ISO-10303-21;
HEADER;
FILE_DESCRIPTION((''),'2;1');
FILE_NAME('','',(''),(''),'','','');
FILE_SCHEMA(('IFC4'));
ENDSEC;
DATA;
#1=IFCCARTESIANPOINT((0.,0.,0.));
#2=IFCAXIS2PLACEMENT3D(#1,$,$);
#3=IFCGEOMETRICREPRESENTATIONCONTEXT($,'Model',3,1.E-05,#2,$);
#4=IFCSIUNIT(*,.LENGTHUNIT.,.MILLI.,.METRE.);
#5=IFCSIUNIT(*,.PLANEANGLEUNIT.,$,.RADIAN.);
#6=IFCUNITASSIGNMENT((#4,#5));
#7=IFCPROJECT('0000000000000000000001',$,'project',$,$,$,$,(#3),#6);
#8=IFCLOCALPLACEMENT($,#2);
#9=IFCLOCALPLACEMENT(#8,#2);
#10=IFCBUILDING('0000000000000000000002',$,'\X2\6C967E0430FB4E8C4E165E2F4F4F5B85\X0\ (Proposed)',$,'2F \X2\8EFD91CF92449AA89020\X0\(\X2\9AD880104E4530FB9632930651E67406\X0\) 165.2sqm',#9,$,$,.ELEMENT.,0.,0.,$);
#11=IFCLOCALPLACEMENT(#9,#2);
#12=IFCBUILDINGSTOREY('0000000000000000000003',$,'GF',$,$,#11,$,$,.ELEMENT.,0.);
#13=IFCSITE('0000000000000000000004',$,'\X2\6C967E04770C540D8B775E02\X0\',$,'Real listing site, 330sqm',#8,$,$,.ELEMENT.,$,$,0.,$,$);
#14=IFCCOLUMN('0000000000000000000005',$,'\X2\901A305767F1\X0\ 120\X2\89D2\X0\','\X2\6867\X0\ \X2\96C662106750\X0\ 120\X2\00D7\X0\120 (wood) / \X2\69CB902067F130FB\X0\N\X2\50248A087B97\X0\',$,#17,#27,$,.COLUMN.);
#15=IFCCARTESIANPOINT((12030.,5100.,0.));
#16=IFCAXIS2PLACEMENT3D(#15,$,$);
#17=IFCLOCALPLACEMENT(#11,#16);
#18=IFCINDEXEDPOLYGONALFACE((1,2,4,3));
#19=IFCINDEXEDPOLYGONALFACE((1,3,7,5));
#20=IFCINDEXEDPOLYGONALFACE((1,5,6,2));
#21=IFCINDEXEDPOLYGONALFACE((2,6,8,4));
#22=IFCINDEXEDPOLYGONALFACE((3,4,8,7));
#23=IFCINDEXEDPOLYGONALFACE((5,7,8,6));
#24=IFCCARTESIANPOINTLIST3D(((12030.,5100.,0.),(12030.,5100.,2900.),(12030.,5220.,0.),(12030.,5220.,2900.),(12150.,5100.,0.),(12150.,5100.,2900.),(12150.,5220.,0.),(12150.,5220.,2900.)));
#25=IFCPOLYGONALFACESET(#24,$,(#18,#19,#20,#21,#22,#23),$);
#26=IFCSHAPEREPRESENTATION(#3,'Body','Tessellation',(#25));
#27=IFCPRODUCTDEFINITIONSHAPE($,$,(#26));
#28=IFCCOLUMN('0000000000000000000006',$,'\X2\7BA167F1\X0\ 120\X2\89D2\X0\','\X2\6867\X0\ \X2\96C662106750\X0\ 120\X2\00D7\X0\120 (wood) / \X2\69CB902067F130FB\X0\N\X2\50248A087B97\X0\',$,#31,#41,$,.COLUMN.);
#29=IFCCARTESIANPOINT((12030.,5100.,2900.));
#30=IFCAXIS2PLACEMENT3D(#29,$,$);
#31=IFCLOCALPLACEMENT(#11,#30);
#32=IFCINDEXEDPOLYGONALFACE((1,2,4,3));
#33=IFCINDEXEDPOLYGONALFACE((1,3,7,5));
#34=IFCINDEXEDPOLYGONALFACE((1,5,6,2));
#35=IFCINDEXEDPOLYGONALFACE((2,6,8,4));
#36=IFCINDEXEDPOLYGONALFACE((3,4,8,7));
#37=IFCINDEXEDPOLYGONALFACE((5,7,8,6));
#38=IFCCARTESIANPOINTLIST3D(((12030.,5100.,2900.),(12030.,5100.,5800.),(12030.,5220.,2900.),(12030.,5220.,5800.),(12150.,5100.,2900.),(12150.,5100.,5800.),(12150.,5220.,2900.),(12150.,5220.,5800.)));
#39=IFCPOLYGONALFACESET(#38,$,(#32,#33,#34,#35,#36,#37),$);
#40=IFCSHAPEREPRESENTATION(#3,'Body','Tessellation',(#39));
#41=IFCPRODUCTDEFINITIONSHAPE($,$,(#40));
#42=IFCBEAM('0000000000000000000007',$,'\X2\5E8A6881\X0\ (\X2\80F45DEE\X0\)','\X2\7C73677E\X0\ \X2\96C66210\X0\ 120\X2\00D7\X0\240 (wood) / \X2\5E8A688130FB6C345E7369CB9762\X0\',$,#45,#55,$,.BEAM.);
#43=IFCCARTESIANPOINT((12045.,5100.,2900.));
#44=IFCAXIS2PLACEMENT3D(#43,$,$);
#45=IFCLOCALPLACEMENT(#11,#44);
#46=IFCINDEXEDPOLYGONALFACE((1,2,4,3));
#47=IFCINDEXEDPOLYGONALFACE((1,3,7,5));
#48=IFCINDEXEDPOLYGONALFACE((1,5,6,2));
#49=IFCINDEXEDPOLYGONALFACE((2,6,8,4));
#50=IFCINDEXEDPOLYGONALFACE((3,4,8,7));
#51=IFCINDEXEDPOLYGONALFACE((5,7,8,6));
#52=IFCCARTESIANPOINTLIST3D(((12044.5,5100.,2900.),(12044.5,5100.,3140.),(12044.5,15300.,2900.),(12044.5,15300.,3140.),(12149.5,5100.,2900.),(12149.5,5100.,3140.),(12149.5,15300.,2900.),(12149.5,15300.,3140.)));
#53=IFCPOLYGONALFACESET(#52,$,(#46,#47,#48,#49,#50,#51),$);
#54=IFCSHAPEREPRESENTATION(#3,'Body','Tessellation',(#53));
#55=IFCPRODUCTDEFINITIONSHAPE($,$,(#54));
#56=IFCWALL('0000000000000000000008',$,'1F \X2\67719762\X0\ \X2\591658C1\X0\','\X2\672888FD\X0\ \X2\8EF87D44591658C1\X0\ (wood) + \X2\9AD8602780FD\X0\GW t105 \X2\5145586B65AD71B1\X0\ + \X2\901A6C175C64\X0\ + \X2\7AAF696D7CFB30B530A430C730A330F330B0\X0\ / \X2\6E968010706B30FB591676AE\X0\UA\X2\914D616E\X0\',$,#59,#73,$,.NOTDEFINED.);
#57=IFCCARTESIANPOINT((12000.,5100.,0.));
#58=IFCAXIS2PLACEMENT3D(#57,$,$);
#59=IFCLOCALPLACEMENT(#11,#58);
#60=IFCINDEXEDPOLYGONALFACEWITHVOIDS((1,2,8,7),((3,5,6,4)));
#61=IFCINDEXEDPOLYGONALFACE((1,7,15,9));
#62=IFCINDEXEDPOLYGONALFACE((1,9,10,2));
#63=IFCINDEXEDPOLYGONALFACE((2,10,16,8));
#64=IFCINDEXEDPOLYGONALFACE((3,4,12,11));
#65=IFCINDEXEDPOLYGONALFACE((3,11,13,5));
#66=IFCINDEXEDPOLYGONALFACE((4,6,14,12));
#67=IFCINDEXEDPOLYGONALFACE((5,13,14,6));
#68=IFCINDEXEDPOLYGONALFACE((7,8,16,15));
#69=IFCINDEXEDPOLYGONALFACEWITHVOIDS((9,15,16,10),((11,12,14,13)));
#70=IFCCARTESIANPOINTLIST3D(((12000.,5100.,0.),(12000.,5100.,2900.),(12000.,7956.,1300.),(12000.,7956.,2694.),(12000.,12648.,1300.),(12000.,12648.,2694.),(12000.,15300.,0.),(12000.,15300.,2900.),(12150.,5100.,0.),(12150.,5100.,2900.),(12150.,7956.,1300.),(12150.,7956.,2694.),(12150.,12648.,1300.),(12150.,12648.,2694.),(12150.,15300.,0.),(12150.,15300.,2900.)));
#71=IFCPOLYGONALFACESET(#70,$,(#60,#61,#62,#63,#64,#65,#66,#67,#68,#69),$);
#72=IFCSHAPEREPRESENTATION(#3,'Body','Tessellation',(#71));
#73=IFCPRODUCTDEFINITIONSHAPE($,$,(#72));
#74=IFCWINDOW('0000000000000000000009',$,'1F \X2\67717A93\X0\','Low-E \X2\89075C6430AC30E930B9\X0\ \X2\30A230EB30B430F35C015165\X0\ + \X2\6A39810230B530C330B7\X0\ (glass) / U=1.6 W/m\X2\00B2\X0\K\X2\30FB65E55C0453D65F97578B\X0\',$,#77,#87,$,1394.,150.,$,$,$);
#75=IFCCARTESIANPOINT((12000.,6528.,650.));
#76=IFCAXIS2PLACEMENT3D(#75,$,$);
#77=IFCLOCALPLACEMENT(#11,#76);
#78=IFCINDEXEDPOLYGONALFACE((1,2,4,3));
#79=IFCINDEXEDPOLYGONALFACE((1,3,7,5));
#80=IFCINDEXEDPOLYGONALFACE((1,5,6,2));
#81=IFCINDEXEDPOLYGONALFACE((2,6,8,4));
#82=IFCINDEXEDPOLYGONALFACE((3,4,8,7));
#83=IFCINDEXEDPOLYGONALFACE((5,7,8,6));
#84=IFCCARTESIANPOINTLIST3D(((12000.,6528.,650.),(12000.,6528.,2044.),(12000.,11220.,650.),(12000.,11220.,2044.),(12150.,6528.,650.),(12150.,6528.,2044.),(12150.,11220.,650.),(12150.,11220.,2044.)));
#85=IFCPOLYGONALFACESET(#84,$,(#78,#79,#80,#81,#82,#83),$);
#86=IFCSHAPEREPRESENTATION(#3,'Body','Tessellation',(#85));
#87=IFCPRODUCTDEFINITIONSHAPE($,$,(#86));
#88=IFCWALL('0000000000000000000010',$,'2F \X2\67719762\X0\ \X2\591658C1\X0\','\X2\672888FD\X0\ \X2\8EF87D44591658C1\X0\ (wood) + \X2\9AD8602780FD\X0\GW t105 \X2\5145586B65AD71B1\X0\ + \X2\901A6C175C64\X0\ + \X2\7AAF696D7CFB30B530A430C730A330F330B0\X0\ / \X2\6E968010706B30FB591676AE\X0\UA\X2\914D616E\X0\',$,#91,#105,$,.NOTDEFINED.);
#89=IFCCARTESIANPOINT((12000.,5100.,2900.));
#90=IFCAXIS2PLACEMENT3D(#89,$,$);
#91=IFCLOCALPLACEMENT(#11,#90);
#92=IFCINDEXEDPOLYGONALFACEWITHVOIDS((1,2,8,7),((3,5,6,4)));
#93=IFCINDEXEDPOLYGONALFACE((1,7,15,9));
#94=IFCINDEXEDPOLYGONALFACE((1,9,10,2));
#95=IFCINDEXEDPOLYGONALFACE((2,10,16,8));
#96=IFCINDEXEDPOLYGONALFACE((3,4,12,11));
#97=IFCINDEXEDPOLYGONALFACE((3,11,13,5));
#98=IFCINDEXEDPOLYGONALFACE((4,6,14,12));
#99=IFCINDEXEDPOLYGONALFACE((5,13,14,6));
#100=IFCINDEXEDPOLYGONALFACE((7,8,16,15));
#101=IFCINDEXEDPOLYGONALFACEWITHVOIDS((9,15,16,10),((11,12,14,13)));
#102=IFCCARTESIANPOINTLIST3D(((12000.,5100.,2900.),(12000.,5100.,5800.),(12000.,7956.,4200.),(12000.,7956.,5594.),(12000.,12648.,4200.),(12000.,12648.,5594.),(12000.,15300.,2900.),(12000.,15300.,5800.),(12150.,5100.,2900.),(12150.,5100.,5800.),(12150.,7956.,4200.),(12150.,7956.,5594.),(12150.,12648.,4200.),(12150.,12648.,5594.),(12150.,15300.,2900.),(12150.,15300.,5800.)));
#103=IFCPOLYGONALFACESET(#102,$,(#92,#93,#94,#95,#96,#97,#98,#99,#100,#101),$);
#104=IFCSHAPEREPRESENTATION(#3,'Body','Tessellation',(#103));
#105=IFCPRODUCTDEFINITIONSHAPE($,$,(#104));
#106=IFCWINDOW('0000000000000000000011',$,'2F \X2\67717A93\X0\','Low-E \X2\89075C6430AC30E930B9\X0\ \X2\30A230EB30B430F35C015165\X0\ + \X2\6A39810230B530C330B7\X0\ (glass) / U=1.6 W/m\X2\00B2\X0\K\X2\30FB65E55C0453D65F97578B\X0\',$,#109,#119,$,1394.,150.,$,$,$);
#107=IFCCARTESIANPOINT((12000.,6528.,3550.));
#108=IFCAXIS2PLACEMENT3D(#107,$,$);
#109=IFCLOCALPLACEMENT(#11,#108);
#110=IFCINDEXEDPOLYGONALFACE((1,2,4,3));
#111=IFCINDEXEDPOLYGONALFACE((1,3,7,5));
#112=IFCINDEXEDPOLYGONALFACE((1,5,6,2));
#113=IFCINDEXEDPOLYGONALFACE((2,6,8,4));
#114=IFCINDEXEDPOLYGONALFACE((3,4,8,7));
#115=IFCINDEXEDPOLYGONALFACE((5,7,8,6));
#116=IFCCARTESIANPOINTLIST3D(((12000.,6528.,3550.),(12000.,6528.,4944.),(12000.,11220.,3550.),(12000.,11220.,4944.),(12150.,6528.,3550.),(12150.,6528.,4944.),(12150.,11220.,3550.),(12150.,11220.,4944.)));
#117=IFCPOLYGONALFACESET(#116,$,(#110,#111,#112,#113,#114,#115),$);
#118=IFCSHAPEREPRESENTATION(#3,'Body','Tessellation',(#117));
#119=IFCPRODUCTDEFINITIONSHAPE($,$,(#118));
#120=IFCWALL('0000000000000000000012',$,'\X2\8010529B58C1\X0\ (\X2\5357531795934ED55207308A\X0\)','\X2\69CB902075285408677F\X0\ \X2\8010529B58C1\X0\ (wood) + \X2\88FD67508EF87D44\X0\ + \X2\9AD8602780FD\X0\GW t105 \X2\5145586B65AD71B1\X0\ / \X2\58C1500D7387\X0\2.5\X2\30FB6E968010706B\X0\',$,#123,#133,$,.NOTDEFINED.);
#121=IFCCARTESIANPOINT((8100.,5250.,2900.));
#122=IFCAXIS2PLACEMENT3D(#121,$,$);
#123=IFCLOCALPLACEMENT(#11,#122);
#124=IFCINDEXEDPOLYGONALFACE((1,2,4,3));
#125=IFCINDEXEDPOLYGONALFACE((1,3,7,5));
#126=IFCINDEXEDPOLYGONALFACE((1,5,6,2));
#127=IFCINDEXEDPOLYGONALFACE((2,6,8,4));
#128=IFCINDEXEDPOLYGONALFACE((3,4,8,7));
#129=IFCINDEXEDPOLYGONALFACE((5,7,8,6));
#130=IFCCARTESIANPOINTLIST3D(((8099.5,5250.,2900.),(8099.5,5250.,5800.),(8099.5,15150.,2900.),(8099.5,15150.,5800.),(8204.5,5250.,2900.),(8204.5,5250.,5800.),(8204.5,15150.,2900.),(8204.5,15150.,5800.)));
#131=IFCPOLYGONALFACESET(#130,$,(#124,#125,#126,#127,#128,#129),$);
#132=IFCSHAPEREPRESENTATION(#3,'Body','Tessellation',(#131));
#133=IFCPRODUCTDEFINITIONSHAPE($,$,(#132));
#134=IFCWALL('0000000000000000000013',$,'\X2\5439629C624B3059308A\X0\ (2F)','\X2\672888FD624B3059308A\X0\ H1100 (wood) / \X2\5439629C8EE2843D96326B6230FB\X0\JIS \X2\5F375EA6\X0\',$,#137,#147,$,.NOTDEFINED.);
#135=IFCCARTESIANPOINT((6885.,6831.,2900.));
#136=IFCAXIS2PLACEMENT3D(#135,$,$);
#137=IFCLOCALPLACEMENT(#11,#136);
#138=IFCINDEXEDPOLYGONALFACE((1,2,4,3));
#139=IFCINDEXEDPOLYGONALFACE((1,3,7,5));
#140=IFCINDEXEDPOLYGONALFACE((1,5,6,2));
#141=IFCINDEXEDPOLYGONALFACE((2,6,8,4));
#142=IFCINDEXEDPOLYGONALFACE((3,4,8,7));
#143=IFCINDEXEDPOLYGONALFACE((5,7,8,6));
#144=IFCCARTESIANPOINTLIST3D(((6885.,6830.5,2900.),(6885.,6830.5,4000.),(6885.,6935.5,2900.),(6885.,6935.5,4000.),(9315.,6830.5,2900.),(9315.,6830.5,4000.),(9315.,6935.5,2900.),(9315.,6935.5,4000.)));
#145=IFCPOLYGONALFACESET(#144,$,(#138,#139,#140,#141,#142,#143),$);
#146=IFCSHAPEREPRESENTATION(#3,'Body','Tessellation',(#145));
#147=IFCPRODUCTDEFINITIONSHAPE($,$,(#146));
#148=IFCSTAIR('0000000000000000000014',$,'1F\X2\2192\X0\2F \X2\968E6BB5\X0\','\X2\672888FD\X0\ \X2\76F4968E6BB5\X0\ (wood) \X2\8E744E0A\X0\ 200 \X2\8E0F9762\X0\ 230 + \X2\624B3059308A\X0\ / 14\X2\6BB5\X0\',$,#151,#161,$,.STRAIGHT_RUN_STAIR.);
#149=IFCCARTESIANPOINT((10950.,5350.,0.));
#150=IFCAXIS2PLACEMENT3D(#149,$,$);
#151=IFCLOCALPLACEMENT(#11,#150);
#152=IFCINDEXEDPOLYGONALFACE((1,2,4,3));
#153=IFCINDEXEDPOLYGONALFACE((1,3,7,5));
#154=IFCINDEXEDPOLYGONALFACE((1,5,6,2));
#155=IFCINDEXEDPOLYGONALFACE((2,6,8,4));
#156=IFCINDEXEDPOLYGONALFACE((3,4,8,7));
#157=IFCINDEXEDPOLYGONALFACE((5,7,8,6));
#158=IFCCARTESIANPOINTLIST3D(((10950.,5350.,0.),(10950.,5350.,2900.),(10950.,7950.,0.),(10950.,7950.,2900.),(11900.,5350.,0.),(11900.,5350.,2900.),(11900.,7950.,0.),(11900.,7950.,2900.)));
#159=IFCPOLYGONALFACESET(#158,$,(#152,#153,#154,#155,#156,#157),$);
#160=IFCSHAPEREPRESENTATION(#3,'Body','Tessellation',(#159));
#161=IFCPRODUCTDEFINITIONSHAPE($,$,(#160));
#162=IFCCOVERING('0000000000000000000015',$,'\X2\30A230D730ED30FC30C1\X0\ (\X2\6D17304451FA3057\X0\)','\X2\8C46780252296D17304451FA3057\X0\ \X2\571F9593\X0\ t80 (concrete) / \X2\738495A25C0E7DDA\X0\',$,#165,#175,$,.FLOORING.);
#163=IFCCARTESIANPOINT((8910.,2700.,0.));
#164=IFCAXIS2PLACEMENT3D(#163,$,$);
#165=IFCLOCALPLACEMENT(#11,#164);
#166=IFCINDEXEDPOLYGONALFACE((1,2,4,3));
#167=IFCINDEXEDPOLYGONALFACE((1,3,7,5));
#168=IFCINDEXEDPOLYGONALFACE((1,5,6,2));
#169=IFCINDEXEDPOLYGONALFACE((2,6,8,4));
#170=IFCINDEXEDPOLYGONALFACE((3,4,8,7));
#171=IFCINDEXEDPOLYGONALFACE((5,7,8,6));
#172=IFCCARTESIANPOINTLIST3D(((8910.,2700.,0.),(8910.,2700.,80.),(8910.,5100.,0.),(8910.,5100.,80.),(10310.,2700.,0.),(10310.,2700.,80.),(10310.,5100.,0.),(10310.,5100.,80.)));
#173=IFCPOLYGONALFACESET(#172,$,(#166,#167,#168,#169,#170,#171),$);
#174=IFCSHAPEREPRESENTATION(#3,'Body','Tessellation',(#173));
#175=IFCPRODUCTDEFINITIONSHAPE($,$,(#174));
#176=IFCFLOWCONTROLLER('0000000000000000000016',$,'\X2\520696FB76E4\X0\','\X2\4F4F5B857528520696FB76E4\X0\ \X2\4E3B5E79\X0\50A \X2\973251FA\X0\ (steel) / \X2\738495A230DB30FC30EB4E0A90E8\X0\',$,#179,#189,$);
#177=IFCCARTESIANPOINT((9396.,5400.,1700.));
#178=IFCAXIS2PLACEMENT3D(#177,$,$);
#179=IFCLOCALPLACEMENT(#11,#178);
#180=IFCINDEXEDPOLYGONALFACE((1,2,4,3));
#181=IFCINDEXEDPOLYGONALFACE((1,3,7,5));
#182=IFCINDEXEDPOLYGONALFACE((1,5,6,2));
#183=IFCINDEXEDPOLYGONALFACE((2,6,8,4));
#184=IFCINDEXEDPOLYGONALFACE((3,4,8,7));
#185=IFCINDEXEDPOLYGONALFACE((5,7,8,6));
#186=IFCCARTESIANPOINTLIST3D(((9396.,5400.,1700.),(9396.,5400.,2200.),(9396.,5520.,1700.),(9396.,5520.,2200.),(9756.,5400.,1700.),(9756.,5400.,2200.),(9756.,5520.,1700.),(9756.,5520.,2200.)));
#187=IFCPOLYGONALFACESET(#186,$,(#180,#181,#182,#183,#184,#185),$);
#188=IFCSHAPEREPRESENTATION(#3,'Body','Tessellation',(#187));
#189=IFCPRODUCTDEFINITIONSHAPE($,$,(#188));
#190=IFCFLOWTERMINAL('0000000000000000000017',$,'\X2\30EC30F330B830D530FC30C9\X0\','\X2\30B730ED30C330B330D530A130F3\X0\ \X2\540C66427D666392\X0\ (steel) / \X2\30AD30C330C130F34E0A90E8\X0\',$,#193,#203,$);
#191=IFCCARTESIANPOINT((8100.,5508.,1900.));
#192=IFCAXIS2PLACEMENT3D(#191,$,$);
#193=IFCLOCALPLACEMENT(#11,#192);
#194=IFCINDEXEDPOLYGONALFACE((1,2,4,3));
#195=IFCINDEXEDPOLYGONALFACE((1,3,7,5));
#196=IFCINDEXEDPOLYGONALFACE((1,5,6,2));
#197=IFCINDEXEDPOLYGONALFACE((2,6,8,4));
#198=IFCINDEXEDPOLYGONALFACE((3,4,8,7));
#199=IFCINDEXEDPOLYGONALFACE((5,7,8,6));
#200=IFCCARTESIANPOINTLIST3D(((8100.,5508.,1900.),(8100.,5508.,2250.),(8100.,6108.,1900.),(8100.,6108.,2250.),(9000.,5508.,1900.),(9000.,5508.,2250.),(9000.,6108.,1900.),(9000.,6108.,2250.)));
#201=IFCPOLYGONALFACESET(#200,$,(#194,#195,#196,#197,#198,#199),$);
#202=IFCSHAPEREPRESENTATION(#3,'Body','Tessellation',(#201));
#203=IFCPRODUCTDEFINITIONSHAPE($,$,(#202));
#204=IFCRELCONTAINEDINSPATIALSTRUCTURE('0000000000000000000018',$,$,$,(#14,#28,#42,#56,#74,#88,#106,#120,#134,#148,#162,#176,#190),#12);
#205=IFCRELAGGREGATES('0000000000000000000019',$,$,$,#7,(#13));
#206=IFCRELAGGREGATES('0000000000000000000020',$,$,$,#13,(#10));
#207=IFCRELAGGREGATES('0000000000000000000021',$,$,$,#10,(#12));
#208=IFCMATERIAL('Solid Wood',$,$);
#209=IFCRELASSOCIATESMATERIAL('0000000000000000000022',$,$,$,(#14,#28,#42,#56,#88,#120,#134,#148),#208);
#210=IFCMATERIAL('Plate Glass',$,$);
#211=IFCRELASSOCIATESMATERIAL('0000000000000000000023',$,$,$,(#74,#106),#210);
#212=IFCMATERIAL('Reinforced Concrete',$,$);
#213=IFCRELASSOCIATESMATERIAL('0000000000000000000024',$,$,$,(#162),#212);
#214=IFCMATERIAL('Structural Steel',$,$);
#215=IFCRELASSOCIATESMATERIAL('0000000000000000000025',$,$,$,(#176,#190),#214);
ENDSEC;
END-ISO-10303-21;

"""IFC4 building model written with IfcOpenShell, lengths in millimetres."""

from ifc_helpers import new_model, si_unit, frame, frame_2d, origin, place, context, project, spatial, rectangle, extrude, material, element, fill, save


model = new_model("IFC4")

# Units and contexts
model_context = context("Model", 3, precision=1e-05, world=origin())
ifc_project = project(units=[si_unit("LENGTHUNIT", "METRE", prefix="MILLI"), si_unit("PLANEANGLEUNIT", "RADIAN")], contexts=[model_context])

# Site, building, storey
site_placement = place(None, origin())
site = spatial("IfcSite", under=ifc_project, at=site_placement, Name="沖縄県名護市", ObjectType="Real listing site, 330sqm", CompositionType="ELEMENT", RefElevation=0.0)
building_placement = place(site_placement, origin())
building = spatial("IfcBuilding", under=site, at=building_placement, Name="沖縄・二世帯住宅 (Proposed)", ObjectType="2F 軽量鉄骨造(高耐久・防錆処理) 165.2sqm", CompositionType="ELEMENT", ElevationOfRefHeight=0.0, ElevationOfTerrain=0.0)
storey_placement = place(building_placement, origin())
storey = spatial("IfcBuildingStorey", under=building, at=storey_placement, Name="GF", CompositionType="ELEMENT", Elevation=0.0)

# Columns
ifc_material_1 = material(Name="Solid Wood")
column_1_placement = place(storey_placement, frame((12030.0, 5100.0, 0.0)))
element("IfcColumn", 1, at=column_1_placement, inside=storey, material=ifc_material_1, Name="通し柱 120角", Description="桧 集成材 120×120 (wood) / 構造柱・N値計算", PredefinedType="COLUMN", context=model_context, shape_type="SweptSolid", body=[
    extrude(rectangle(XDim=120.0, YDim=120.0, at=frame_2d((60.0, 60.0))), frame((12030.0, 5100.0, 0.0)), (0.0, 0.0, 1.0), 2900.0),
])
column_2_placement = place(storey_placement, frame((12030.0, 5100.0, 2900.0)))
element("IfcColumn", 2, at=column_2_placement, inside=storey, material=ifc_material_1, Name="管柱 120角", Description="桧 集成材 120×120 (wood) / 構造柱・N値計算", PredefinedType="COLUMN", context=model_context, shape_type="SweptSolid", body=[
    extrude(rectangle(XDim=120.0, YDim=120.0, at=frame_2d((60.0, 60.0))), frame((12030.0, 5100.0, 2900.0)), (0.0, 0.0, 1.0), 2900.0),
])

# Beam
beam_1_placement = place(storey_placement, frame((12045.0, 5100.0, 2900.0)))
element("IfcBeam", 3, at=beam_1_placement, inside=storey, material=ifc_material_1, Name="床梁 (胴差)", Description="米松 集成 120×240 (wood) / 床梁・水平構面", PredefinedType="BEAM", context=model_context, shape_type="SweptSolid", body=[
    extrude(rectangle(XDim=105.0, YDim=10200.0, at=frame_2d((52.0, 5100.0))), frame((12045.0, 5100.0, 2900.0)), (0.0, 0.0, 1.0), 240.0),
])

# Wall, opening, window
wall_1_placement = place(storey_placement, frame((12000.0, 5100.0, 0.0)))
wall_1 = element("IfcWall", 4, at=wall_1_placement, inside=storey, material=ifc_material_1, Name="1F 東面 外壁", Description="木製 軸組外壁 (wood) + 高性能GW t105 充填断熱 + 通気層 + 窯業系サイディング / 準耐火・外皮UA配慮", PredefinedType="NOTDEFINED", context=model_context, shape_type="SweptSolid", body=[
    extrude(rectangle(XDim=150.0, YDim=10200.0, at=frame_2d((75.0, 5100.0))), frame((12000.0, 5100.0, 0.0)), (0.0, 0.0, 1.0), 2900.0),
])
opening_1_placement = place(storey_placement, frame((12000.0, 6528.0, 650.0)))
opening_1 = element("IfcOpeningElement", 5, at=opening_1_placement, cuts=wall_1, PredefinedType="NOTDEFINED", context=model_context, shape_type="SweptSolid", body=[
    extrude(rectangle(XDim=150.0, YDim=4692.0, at=frame_2d((75.0, 2346.0))), frame((12000.0, 6528.0, 650.0)), (0.0, 0.0, 1.0), 1394.0),
])
ifc_material_2 = material(Name="Plate Glass")
window_1_placement = place(storey_placement, frame((12000.0, 6528.0, 650.0)))
window_1 = element("IfcWindow", 6, at=window_1_placement, inside=storey, material=ifc_material_2, Name="1F 東窓", Description="Low-E 複層ガラス アルゴン封入 + 樹脂サッシ (glass) / U=1.6 W/m²K・日射取得型", OverallHeight=1394.0, OverallWidth=150.0, context=model_context, shape_type="SweptSolid", body=[
    extrude(rectangle(XDim=150.0, YDim=4692.0, at=frame_2d((75.0, 2346.0))), frame((12000.0, 6528.0, 650.0)), (0.0, 0.0, 1.0), 1394.0),
])
fill(opening_1, window_1)

# Wall, opening, window
wall_2_placement = place(storey_placement, frame((12000.0, 5100.0, 2900.0)))
wall_2 = element("IfcWall", 7, at=wall_2_placement, inside=storey, material=ifc_material_1, Name="2F 東面 外壁", Description="木製 軸組外壁 (wood) + 高性能GW t105 充填断熱 + 通気層 + 窯業系サイディング / 準耐火・外皮UA配慮", PredefinedType="NOTDEFINED", context=model_context, shape_type="SweptSolid", body=[
    extrude(rectangle(XDim=150.0, YDim=10200.0, at=frame_2d((75.0, 5100.0))), frame((12000.0, 5100.0, 2900.0)), (0.0, 0.0, 1.0), 2900.0),
])
opening_2_placement = place(storey_placement, frame((12000.0, 6528.0, 3550.0)))
opening_2 = element("IfcOpeningElement", 8, at=opening_2_placement, cuts=wall_2, PredefinedType="NOTDEFINED", context=model_context, shape_type="SweptSolid", body=[
    extrude(rectangle(XDim=150.0, YDim=4692.0, at=frame_2d((75.0, 2346.0))), frame((12000.0, 6528.0, 3550.0)), (0.0, 0.0, 1.0), 1394.0),
])
window_2_placement = place(storey_placement, frame((12000.0, 6528.0, 3550.0)))
window_2 = element("IfcWindow", 9, at=window_2_placement, inside=storey, material=ifc_material_2, Name="2F 東窓", Description="Low-E 複層ガラス アルゴン封入 + 樹脂サッシ (glass) / U=1.6 W/m²K・日射取得型", OverallHeight=1394.0, OverallWidth=150.0, context=model_context, shape_type="SweptSolid", body=[
    extrude(rectangle(XDim=150.0, YDim=4692.0, at=frame_2d((75.0, 2346.0))), frame((12000.0, 6528.0, 3550.0)), (0.0, 0.0, 1.0), 1394.0),
])
fill(opening_2, window_2)

# Walls
wall_3_placement = place(storey_placement, frame((8100.0, 5250.0, 2900.0)))
element("IfcWall", 10, at=wall_3_placement, inside=storey, material=ifc_material_1, Name="耐力壁 (南北間仕切り)", Description="構造用合板 耐力壁 (wood) + 製材軸組 + 高性能GW t105 充填断熱 / 壁倍率2.5・準耐火", PredefinedType="NOTDEFINED", context=model_context, shape_type="SweptSolid", body=[
    extrude(rectangle(XDim=105.0, YDim=9900.0, at=frame_2d((52.0, 4950.0))), frame((8100.0, 5250.0, 2900.0)), (0.0, 0.0, 1.0), 2900.0),
])
wall_4_placement = place(storey_placement, frame((6885.0, 6831.0, 2900.0)))
element("IfcWall", 11, at=wall_4_placement, inside=storey, material=ifc_material_1, Name="吹抜手すり (2F)", Description="木製手すり H1100 (wood) / 吹抜転落防止・JIS 強度", PredefinedType="NOTDEFINED", context=model_context, shape_type="SweptSolid", body=[
    extrude(rectangle(XDim=2430.0, YDim=105.0, at=frame_2d((1215.0, 52.0))), frame((6885.0, 6831.0, 2900.0)), (0.0, 0.0, 1.0), 1100.0),
])

# Stair
stair_placement = place(storey_placement, frame((10950.0, 5350.0, 0.0)))
element("IfcStair", 12, at=stair_placement, inside=storey, material=ifc_material_1, Name="1F→2F 階段", Description="木製 直階段 (wood) 蹴上 200 踏面 230 + 手すり / 14段", PredefinedType="STRAIGHT_RUN_STAIR", context=model_context, shape_type="SweptSolid", body=[
    extrude(rectangle(XDim=950.0, YDim=2600.0, at=frame_2d((475.0, 1300.0))), frame((10950.0, 5350.0, 0.0)), (0.0, 0.0, 1.0), 2900.0),
])

# Covering
ifc_material_3 = material(Name="Reinforced Concrete")
covering_placement = place(storey_placement, frame((8910.0, 2700.0, 0.0)))
element("IfcCovering", 13, at=covering_placement, inside=storey, material=ifc_material_3, Name="アプローチ (洗い出し)", Description="豆砂利洗い出し 土間 t80 (concrete) / 玄関導線", PredefinedType="FLOORING", context=model_context, shape_type="SweptSolid", body=[
    extrude(rectangle(XDim=1400.0, YDim=2400.0, at=frame_2d((700.0, 1200.0))), frame((8910.0, 2700.0, 0.0)), (0.0, 0.0, 1.0), 80.0),
])

# Flow controller
ifc_material_4 = material(Name="Structural Steel")
flow_controller_placement = place(storey_placement, frame((9396.0, 5400.0, 1700.0)))
element("IfcFlowController", 14, at=flow_controller_placement, inside=storey, material=ifc_material_4, Name="分電盤", Description="住宅用分電盤 主幹50A 露出 (steel) / 玄関ホール上部", context=model_context, shape_type="SweptSolid", body=[
    extrude(rectangle(XDim=360.0, YDim=120.0, at=frame_2d((180.0, 60.0))), frame((9396.0, 5400.0, 1700.0)), (0.0, 0.0, 1.0), 500.0),
])

# Flow terminal
flow_terminal_1_placement = place(storey_placement, frame((8100.0, 5508.0, 1900.0)))
element("IfcFlowTerminal", 15, at=flow_terminal_1_placement, inside=storey, material=ifc_material_4, Name="レンジフード", Description="シロッコファン 同時給排 (steel) / キッチン上部", context=model_context, shape_type="SweptSolid", body=[
    extrude(rectangle(XDim=900.0, YDim=600.0, at=frame_2d((450.0, 300.0))), frame((8100.0, 5508.0, 1900.0)), (0.0, 0.0, 1.0), 350.0),
])

save(model, "model.ifc")
